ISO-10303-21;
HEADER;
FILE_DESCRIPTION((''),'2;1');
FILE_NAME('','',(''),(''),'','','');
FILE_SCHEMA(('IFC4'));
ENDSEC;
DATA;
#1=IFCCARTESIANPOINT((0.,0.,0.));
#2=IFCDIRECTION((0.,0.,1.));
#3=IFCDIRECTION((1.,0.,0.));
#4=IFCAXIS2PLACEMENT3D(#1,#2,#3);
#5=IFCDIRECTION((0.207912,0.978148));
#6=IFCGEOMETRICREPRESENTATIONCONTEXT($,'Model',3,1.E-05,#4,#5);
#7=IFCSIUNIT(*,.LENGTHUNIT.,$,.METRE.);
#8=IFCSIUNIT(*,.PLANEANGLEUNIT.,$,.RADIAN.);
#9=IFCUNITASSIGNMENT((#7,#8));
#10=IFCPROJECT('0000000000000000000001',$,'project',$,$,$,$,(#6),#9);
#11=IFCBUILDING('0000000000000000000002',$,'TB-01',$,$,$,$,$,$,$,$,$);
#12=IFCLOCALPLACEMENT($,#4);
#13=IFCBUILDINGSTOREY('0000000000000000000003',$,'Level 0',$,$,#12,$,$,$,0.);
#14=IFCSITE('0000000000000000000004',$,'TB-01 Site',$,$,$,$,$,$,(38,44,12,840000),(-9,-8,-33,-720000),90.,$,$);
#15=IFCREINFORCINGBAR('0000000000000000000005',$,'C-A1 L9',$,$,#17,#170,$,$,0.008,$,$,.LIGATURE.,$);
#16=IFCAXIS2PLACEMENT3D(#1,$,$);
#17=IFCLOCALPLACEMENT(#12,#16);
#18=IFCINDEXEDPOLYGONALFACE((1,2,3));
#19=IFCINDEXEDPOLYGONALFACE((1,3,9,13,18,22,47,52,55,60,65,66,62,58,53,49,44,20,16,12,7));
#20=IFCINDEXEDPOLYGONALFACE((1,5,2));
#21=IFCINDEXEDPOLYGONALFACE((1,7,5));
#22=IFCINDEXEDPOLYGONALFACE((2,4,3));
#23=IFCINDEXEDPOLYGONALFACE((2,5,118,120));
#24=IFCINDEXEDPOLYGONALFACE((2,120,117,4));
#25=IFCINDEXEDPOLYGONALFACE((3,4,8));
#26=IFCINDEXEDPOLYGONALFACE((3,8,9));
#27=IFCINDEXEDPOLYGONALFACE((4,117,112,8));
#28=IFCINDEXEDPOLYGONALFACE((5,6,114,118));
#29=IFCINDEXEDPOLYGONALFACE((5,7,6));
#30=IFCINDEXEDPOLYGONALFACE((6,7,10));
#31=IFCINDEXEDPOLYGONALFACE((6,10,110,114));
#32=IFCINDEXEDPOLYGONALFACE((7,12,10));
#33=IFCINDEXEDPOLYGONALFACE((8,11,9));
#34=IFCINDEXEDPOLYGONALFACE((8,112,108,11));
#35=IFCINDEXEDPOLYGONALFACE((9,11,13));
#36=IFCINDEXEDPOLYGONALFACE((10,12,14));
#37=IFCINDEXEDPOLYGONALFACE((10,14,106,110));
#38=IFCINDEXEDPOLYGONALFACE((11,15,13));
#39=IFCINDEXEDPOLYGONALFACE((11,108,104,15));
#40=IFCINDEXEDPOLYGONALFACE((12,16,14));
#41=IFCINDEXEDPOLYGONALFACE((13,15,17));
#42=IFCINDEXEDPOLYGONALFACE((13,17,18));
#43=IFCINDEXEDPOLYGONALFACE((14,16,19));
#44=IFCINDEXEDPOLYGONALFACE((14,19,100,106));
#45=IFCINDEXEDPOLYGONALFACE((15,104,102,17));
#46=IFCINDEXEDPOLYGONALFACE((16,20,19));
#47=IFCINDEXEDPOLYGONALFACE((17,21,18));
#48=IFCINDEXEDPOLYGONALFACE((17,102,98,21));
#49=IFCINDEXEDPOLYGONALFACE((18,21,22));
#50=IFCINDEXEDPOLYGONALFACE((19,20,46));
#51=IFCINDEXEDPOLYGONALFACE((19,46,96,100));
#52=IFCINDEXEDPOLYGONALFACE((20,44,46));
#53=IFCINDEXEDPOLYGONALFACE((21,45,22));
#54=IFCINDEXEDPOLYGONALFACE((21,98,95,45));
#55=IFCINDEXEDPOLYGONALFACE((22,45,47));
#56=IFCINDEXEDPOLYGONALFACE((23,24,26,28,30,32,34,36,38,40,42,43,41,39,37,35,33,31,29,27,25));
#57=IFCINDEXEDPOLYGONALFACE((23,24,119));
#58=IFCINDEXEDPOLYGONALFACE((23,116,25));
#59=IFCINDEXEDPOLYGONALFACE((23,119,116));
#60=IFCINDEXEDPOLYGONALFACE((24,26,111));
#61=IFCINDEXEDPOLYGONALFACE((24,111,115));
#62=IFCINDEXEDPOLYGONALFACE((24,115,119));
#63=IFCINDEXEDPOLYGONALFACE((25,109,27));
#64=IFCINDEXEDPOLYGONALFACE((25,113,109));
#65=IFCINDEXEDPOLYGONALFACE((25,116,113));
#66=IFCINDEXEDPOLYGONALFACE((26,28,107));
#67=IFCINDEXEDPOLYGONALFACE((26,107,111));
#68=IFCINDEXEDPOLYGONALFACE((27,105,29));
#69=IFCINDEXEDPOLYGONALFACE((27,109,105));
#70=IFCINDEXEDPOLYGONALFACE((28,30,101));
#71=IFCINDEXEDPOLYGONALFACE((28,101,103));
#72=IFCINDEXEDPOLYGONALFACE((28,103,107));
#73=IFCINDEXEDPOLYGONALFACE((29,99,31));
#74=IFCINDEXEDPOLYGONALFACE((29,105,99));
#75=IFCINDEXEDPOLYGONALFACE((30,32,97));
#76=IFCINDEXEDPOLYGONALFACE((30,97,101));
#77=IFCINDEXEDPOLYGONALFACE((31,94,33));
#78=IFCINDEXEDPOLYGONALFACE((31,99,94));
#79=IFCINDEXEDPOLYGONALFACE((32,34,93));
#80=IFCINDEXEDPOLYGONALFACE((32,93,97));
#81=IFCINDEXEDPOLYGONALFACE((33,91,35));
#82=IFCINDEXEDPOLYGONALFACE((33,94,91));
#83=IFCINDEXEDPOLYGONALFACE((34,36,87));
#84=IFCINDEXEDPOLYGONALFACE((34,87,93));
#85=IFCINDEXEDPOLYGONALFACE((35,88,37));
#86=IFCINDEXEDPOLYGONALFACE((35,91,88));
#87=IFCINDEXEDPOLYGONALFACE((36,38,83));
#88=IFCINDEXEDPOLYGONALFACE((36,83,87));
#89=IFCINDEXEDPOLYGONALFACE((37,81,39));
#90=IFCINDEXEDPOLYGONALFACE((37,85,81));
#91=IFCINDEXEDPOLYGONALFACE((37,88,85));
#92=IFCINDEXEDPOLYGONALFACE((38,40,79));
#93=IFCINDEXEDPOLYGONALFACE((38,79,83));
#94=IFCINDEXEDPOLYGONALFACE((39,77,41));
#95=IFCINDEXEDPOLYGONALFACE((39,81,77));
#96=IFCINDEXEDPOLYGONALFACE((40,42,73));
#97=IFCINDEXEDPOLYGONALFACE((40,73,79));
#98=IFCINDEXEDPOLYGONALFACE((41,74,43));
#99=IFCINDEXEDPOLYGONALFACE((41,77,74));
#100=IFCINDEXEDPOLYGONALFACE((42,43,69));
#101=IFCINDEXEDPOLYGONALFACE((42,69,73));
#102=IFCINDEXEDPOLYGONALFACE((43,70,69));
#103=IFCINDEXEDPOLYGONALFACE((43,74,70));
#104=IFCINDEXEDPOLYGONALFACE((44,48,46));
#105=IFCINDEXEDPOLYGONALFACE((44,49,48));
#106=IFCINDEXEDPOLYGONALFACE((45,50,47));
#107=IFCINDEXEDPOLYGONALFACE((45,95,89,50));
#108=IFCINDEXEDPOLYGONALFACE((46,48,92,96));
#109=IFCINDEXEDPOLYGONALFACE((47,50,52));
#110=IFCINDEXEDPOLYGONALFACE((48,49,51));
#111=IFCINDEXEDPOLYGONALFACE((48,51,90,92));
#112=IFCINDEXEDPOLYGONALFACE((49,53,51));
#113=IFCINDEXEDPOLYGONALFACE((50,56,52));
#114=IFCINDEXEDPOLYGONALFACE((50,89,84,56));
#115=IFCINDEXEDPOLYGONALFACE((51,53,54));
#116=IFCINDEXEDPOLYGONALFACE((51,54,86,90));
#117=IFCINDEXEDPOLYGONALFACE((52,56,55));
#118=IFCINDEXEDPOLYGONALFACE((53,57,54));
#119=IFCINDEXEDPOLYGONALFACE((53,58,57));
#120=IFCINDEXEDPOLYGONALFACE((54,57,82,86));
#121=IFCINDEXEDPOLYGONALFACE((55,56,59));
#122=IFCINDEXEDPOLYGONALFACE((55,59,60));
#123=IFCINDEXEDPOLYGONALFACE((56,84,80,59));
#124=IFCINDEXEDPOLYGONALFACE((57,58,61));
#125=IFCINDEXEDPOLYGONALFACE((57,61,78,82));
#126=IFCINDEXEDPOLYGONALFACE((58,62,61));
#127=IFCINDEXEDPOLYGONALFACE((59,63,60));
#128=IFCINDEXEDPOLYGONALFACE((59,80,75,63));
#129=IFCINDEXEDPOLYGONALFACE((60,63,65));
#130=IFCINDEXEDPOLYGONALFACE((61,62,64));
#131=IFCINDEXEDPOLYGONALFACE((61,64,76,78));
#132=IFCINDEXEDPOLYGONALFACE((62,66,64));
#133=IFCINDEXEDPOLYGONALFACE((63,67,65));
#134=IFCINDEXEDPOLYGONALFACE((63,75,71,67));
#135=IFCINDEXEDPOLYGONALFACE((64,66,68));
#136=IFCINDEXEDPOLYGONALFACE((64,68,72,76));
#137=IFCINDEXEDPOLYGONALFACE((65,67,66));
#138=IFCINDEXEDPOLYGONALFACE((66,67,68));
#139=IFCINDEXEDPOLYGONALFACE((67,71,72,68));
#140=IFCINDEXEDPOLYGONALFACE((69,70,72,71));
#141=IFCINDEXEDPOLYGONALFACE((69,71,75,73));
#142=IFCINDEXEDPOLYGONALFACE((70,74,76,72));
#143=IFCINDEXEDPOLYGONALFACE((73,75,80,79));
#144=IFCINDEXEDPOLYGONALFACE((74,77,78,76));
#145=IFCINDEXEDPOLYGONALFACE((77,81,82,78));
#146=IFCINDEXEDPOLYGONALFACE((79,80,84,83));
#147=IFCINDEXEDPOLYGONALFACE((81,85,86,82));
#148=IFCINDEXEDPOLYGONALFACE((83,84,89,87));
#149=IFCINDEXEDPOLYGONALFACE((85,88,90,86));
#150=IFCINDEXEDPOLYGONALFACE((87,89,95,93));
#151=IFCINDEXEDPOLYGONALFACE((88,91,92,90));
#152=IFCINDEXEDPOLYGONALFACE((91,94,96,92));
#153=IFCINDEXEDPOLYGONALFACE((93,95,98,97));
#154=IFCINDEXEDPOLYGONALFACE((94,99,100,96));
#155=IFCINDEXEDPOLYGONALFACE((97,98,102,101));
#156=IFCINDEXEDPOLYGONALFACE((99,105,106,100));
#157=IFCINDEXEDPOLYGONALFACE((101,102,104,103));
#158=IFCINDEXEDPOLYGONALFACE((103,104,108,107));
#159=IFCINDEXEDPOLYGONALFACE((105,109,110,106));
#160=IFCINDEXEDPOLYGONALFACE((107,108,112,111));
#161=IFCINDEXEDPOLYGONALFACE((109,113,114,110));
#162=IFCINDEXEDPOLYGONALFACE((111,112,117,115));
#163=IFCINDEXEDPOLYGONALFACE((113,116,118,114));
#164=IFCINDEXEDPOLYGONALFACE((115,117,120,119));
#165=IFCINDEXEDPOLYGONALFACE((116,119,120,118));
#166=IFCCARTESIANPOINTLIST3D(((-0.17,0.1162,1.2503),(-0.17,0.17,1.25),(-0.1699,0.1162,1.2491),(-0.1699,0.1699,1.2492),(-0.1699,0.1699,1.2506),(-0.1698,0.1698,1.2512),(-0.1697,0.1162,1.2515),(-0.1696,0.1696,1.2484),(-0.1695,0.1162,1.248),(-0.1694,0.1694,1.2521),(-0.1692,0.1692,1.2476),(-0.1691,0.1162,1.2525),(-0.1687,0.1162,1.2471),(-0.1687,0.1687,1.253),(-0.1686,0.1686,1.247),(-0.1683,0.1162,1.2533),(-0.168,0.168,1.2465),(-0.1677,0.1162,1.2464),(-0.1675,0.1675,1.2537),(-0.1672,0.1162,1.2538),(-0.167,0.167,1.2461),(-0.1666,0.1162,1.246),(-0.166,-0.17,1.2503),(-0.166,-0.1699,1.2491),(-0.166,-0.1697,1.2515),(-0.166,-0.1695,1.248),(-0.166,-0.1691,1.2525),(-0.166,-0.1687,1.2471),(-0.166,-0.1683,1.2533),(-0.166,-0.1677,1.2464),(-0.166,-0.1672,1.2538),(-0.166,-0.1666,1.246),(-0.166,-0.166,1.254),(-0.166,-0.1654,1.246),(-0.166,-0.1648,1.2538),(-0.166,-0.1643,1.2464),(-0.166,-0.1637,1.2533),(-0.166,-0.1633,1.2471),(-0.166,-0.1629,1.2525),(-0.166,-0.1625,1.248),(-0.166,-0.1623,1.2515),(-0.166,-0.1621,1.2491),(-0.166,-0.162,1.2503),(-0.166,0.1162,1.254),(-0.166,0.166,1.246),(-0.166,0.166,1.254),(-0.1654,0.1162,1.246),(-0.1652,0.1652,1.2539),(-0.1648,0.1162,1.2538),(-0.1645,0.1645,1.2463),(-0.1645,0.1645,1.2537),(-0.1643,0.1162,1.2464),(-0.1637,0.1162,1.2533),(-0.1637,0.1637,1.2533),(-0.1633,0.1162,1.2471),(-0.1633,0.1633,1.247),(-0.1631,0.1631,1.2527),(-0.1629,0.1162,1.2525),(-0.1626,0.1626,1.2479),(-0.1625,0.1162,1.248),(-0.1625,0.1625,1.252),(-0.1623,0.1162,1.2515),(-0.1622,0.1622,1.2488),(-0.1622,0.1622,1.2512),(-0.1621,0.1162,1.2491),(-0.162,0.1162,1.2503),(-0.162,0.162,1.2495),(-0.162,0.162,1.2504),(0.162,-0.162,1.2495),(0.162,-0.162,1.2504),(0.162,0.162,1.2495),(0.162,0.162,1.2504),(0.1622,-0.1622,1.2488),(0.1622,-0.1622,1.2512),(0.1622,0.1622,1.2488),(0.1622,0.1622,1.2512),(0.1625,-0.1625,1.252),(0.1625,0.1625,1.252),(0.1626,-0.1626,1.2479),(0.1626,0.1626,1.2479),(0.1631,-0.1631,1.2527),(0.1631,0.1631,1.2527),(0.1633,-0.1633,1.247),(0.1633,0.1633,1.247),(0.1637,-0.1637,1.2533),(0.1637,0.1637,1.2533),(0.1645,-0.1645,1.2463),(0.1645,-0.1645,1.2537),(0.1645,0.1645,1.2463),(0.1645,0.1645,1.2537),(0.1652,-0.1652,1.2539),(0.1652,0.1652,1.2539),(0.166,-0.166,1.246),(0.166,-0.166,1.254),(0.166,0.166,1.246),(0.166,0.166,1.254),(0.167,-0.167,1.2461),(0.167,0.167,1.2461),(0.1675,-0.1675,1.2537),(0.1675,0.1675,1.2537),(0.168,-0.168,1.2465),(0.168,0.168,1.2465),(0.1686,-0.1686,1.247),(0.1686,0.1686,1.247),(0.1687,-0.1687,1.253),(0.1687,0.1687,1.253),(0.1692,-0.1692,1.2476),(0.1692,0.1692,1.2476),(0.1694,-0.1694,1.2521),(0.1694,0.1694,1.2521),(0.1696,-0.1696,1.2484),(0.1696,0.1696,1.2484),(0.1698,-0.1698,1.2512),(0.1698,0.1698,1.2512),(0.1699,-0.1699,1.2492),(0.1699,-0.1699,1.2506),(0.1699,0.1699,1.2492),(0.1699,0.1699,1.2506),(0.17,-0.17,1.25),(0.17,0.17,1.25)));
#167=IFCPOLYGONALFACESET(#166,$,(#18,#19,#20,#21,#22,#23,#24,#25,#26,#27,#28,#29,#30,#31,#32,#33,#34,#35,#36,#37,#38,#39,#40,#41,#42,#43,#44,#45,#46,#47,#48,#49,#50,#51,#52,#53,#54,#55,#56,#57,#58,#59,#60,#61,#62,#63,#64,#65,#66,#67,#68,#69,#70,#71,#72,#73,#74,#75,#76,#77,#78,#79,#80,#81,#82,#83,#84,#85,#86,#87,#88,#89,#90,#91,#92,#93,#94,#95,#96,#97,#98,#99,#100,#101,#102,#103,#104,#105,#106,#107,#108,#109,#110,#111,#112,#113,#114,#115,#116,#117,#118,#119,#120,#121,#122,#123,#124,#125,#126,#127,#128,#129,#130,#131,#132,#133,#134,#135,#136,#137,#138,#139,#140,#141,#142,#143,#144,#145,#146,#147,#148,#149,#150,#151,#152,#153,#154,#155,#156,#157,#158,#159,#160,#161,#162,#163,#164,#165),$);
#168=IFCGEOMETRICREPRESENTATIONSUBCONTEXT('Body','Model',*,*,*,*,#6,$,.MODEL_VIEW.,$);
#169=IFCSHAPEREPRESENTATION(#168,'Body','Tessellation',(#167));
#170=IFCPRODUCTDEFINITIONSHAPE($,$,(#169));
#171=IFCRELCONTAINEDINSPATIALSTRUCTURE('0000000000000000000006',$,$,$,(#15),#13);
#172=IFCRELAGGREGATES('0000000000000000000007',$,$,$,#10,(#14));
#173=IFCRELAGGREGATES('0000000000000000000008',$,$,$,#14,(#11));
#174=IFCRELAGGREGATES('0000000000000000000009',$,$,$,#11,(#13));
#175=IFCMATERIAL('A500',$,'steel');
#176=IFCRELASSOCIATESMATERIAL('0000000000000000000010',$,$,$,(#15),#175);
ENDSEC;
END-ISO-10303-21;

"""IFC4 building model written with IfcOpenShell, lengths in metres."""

from ifc_helpers import new_model, entity, si_unit, direction, origin_with_axes, place, context, subcontext, project, spatial, material, element, save


model = new_model("IFC4")

# Units and contexts
model_context = context("Model", 3, precision=1e-05, world=origin_with_axes(), true_north=direction((0.207912, 0.978148)))
body_context = subcontext(model_context, "Body", "Model", "MODEL_VIEW")
ifc_project = project(units=[si_unit("LENGTHUNIT", "METRE"), si_unit("PLANEANGLEUNIT", "RADIAN")], contexts=[model_context])

# Site, building, storey
site = spatial("IfcSite", under=ifc_project, Name="TB-01 Site", RefLatitude=(38, 44, 12, 840000), RefLongitude=(-9, -8, -33, -720000), RefElevation=90.0)
building = spatial("IfcBuilding", under=site, Name="TB-01")
storey_placement = place(None, origin_with_axes())
storey = spatial("IfcBuildingStorey", under=building, at=storey_placement, Name="Level 0", Elevation=0.0)

# Reinforcing bar
ifc_material_1 = material(Name="A500", Category="steel")
reinforcing_bar_1_placement = place(storey_placement, origin_with_axes())
element("IfcReinforcingBar", 1, at=reinforcing_bar_1_placement, inside=storey, material=ifc_material_1, Name="C-A1 L9", NominalDiameter=0.008, PredefinedType="LIGATURE", context=body_context, shape_type="AdvancedSweptSolid", body=[
    entity("IfcSweptDiskSolid", entity("IfcPolyline", [entity("IfcCartesianPoint", [-0.166, -0.166, 1.25]), entity("IfcCartesianPoint", [0.166, -0.166, 1.25]), entity("IfcCartesianPoint", [0.166, 0.166, 1.25]), entity("IfcCartesianPoint", [-0.166, 0.166, 1.25]), entity("IfcCartesianPoint", [-0.166, 0.1162, 1.25])]), 0.004),
])

save(model, "model.ifc")
